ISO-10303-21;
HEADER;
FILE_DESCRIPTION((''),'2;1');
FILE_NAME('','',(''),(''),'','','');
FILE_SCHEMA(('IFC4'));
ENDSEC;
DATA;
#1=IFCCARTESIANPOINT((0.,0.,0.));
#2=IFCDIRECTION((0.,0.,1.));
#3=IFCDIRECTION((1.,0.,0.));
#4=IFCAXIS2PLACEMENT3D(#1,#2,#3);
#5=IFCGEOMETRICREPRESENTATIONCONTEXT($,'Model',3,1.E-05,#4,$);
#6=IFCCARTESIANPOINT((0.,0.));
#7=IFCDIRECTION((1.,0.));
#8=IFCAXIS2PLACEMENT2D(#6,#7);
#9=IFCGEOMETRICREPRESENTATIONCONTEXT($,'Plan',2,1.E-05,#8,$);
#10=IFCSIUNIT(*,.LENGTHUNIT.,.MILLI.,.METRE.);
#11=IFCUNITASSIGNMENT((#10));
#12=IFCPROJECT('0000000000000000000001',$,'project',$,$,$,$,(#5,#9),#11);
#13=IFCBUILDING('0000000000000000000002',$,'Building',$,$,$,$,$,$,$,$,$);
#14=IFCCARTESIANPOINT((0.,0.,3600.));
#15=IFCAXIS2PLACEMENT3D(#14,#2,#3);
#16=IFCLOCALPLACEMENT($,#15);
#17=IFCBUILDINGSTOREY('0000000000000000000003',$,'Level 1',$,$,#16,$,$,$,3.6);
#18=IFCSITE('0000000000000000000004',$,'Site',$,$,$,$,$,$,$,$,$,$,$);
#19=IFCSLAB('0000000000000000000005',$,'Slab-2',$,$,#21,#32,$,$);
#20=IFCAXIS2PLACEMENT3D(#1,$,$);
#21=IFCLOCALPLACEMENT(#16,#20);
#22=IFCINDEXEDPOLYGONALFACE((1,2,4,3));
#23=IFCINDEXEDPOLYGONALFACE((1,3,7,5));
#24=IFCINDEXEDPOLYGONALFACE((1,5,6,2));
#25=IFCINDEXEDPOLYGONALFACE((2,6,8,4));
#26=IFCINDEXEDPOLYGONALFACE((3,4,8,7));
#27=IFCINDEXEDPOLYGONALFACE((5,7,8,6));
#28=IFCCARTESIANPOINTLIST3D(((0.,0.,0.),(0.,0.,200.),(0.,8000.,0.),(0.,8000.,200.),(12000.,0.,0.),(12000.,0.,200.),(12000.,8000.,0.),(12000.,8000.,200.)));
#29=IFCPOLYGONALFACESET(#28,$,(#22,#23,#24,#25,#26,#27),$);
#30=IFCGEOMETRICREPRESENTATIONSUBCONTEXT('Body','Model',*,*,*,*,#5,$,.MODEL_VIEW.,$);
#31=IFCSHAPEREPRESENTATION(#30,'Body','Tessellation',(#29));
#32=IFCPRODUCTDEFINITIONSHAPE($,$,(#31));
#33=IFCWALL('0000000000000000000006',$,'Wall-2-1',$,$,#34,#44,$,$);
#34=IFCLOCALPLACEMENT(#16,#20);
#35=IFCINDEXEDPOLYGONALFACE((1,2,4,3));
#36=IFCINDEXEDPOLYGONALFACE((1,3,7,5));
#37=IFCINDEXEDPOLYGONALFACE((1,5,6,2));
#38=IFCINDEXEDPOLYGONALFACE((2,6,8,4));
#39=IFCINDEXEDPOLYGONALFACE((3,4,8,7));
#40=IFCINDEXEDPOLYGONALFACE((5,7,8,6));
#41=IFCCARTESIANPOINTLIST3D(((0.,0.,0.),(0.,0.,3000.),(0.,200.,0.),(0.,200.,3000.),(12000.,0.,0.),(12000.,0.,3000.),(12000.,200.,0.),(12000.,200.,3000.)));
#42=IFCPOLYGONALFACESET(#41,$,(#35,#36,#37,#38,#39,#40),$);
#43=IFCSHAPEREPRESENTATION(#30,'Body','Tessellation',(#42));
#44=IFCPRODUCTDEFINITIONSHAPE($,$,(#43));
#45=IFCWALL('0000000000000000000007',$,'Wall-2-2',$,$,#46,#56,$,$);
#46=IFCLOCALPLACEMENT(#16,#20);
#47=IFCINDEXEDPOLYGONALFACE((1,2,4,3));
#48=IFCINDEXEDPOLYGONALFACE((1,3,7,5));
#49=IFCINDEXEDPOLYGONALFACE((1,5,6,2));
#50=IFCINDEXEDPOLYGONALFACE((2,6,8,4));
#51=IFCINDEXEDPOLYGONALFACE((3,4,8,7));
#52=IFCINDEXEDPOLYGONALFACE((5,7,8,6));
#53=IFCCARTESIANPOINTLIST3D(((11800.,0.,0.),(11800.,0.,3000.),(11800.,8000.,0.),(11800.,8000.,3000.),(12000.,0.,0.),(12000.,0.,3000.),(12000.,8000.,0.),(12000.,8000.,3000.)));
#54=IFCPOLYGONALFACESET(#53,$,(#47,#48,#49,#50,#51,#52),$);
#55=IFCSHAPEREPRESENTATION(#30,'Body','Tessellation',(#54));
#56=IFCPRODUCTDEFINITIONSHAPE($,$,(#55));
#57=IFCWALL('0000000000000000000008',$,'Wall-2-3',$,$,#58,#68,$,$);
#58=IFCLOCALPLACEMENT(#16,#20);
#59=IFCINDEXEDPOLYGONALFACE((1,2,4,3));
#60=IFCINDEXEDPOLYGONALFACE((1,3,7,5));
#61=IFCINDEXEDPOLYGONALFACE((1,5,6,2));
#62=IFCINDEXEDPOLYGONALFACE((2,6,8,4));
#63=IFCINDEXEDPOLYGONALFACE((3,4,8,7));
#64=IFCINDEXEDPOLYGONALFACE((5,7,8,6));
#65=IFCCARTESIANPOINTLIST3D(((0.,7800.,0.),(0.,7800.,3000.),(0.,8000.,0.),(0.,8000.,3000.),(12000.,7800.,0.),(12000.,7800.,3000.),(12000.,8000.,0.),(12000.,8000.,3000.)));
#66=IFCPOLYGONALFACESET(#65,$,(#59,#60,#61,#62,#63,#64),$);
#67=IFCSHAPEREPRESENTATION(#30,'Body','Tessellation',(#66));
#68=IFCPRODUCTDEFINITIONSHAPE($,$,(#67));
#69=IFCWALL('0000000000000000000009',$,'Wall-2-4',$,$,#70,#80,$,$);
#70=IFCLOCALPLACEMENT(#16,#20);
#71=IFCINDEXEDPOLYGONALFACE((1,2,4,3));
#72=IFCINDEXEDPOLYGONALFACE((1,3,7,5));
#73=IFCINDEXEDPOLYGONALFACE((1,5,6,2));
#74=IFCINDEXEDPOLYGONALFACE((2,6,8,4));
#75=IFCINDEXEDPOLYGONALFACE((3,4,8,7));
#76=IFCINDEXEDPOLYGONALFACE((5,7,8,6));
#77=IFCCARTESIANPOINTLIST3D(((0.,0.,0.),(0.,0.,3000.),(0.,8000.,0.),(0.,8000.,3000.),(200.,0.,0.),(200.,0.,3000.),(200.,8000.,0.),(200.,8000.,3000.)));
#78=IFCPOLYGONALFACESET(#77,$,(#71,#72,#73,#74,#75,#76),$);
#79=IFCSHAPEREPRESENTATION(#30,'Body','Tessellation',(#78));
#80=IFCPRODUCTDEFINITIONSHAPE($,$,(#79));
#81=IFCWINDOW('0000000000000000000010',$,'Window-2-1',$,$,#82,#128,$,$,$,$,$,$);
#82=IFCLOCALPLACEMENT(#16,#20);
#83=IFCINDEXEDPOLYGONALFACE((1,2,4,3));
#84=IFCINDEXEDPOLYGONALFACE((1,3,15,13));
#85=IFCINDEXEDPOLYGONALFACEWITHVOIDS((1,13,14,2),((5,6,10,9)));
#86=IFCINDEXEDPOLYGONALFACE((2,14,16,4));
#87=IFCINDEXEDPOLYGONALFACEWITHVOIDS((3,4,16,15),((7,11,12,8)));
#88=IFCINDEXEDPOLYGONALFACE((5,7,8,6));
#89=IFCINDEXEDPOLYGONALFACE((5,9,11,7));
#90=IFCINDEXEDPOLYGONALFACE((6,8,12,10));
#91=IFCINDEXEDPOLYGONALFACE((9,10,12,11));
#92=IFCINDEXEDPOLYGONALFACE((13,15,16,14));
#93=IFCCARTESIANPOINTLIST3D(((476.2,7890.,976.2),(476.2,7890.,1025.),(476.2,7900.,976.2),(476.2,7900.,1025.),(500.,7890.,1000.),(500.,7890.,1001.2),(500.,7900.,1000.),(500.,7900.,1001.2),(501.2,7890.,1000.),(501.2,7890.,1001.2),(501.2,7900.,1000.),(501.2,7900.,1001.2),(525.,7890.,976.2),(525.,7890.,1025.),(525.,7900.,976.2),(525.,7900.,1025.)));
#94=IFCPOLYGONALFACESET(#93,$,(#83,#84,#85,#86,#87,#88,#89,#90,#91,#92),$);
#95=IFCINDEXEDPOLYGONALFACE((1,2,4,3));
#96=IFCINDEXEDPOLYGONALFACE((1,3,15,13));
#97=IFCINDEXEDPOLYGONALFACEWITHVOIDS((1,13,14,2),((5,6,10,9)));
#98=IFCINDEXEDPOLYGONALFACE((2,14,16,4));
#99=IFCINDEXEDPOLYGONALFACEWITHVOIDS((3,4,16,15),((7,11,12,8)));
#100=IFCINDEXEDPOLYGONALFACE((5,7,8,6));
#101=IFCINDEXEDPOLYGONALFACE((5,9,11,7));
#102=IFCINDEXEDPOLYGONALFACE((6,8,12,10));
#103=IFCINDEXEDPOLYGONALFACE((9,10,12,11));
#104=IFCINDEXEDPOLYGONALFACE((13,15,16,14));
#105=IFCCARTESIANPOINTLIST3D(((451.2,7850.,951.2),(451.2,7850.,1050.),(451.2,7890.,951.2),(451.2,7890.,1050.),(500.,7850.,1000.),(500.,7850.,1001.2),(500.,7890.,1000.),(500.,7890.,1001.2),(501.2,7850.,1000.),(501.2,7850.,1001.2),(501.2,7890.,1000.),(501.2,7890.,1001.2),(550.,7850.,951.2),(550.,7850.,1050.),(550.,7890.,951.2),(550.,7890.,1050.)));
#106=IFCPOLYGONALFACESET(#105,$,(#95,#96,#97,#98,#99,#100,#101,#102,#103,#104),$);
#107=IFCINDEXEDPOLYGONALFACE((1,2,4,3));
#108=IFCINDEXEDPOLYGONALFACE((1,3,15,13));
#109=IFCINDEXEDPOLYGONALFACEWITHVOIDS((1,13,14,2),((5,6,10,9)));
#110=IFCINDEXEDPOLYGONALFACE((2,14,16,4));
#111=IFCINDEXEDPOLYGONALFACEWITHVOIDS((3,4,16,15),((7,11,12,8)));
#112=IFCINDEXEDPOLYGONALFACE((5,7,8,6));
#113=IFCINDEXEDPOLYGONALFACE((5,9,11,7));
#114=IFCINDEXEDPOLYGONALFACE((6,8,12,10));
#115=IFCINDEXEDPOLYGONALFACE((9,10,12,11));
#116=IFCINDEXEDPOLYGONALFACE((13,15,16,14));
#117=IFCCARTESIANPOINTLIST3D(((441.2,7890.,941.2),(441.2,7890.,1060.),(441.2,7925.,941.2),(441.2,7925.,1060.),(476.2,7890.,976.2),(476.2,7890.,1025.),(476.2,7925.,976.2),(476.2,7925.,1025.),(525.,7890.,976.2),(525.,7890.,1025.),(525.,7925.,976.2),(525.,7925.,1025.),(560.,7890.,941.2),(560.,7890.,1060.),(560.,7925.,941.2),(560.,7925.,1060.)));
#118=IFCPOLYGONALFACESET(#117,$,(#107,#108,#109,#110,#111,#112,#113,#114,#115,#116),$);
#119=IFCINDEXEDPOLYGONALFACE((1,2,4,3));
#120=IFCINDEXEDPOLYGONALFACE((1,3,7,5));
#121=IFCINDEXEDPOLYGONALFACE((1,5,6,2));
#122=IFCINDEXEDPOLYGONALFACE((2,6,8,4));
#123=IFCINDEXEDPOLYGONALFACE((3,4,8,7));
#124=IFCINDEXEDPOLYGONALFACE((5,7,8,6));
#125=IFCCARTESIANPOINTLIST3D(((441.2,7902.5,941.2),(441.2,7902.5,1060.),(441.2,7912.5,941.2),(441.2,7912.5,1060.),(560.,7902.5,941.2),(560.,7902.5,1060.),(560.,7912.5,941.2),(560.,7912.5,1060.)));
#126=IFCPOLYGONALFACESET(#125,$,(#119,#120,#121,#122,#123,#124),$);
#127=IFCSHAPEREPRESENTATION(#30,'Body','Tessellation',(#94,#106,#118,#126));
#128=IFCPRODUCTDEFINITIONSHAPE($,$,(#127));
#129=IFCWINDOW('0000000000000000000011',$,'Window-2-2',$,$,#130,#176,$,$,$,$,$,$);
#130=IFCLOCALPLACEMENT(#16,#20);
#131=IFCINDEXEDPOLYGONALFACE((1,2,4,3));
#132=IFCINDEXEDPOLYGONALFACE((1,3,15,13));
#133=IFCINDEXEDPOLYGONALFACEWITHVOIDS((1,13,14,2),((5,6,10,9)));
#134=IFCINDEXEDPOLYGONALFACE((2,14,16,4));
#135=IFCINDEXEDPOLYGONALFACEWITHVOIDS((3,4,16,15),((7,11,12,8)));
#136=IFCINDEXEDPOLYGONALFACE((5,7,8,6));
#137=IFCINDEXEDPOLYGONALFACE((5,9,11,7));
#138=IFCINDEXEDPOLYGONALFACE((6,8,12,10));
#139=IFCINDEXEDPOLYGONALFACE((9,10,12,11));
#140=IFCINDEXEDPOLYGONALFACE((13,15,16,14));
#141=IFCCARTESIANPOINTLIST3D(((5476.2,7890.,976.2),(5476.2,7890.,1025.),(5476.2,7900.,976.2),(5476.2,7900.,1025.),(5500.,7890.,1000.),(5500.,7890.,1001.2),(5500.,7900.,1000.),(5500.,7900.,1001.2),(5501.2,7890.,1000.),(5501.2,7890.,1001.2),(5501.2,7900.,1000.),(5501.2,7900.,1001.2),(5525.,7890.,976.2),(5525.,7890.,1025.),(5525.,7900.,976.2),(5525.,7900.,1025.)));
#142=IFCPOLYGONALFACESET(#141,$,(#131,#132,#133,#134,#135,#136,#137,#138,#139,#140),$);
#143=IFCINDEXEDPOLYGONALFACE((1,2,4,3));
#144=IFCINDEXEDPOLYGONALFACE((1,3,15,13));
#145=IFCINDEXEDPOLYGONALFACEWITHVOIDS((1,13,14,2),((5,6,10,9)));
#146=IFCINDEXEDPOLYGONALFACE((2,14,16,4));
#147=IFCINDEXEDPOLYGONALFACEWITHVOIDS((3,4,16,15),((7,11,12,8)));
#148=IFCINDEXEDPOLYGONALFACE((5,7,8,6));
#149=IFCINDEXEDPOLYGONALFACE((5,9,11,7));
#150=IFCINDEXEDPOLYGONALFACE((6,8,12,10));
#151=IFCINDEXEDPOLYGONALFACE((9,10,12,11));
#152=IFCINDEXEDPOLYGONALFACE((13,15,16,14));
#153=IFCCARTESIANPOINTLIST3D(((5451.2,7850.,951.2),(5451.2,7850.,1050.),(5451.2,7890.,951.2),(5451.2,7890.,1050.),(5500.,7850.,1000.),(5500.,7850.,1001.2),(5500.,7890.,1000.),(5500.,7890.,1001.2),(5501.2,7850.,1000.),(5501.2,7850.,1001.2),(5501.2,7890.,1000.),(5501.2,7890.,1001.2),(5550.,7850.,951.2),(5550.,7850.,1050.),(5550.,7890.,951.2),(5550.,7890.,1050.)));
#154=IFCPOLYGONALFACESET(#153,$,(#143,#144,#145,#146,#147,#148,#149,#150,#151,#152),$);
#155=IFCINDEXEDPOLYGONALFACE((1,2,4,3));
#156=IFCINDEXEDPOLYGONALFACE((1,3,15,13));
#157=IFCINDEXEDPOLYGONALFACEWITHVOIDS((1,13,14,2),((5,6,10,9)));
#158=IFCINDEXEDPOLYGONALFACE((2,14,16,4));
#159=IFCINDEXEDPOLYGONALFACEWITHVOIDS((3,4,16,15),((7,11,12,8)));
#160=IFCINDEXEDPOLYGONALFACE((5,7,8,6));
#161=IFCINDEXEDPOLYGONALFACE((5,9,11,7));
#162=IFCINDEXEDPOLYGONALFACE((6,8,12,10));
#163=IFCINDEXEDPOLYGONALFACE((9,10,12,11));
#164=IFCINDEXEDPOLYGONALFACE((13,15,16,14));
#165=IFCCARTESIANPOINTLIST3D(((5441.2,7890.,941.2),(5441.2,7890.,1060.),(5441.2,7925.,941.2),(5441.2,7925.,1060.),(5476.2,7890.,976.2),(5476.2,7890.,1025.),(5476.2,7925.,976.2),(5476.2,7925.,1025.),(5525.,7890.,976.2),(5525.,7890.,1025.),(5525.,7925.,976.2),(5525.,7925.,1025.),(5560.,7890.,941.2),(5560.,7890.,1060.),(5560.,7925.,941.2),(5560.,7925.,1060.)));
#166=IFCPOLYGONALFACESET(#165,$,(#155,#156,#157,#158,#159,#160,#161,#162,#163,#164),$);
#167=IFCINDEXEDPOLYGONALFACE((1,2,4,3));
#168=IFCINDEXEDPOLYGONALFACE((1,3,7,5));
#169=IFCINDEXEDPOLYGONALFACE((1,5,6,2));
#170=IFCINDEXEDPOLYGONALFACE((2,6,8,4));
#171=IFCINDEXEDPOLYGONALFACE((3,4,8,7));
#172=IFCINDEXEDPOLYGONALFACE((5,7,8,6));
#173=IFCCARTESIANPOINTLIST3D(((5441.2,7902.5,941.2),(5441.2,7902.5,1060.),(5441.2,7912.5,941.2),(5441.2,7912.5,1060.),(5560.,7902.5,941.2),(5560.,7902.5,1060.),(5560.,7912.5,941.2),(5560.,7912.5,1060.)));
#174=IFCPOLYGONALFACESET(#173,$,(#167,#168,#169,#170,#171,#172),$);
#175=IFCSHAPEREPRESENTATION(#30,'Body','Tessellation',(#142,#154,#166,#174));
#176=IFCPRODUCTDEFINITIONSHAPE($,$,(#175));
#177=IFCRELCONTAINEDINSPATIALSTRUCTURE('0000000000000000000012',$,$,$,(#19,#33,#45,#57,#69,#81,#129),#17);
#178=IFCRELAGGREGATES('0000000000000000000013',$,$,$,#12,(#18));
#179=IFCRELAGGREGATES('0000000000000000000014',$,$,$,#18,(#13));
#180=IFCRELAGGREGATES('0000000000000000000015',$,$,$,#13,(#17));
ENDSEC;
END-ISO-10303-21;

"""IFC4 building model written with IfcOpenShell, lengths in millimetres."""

from ifc_helpers import new_model, si_unit, frame, origin_with_axes, origin_2d_with_axis, place, context, subcontext, project, spatial, line, indexed_curve, outline, extrude, element, save


model = new_model("IFC4")

# Units and contexts
model_context = context("Model", 3, precision=1e-05, world=origin_with_axes())
plan_context = context("Plan", 2, precision=1e-05, world=origin_2d_with_axis())
body_context = subcontext(model_context, "Body", "Model", "MODEL_VIEW")
ifc_project = project(units=[si_unit("LENGTHUNIT", "METRE", prefix="MILLI")], contexts=[model_context, plan_context])

# Site, building, storey
site = spatial("IfcSite", under=ifc_project, Name="Site")
building = spatial("IfcBuilding", under=site, Name="Building")
storey_placement = place(None, frame((0.0, 0.0, 3600.0), z_axis=(0.0, 0.0, 1.0), x_axis=(1.0, 0.0, 0.0)))
storey = spatial("IfcBuildingStorey", under=building, at=storey_placement, Name="Level 1", Elevation=3.6)

# Slab
slab_placement = place(storey_placement, origin_with_axes())
element("IfcSlab", 1, at=slab_placement, inside=storey, Name="Slab-2", context=body_context, shape_type="SweptSolid", body=[
    extrude(outline(indexed_curve([(0.0, 0.0), (12000.0, 0.0), (12000.0, 8000.0), (0.0, 8000.0), (0.0, 0.0)])), None, (0.0, 0.0, 1.0), 200.0),
])

# Walls
wall_1_placement = place(storey_placement, origin_with_axes())
element("IfcWall", 2, at=wall_1_placement, inside=storey, Name="Wall-2-1", context=body_context, shape_type="SweptSolid", body=[
    extrude(outline(indexed_curve([(0.0, 0.0), (0.0, 200.0), (12000.0, 200.0), (12000.0, 0.0), (0.0, 0.0)], self_intersect=False)), origin_with_axes(), (0.0, 0.0, 1.0), 3000.0),
])
wall_2_placement = place(storey_placement, frame((12000.0, 0.0, 0.0), z_axis=(0.0, 0.0, 1.0), x_axis=(0.0, 1.0, 0.0)))
element("IfcWall", 3, at=wall_2_placement, inside=storey, Name="Wall-2-2", context=body_context, shape_type="SweptSolid", body=[
    extrude(outline(indexed_curve([(0.0, 0.0), (0.0, 200.0), (8000.0, 200.0), (8000.0, 0.0), (0.0, 0.0)], self_intersect=False)), origin_with_axes(), (0.0, 0.0, 1.0), 3000.0),
])
wall_3_placement = place(storey_placement, frame((12000.0, 8000.0, 0.0), z_axis=(0.0, 0.0, 1.0), x_axis=(-1.0, 0.0, 0.0)))
element("IfcWall", 4, at=wall_3_placement, inside=storey, Name="Wall-2-3", context=body_context, shape_type="SweptSolid", body=[
    extrude(outline(indexed_curve([(0.0, 0.0), (0.0, 200.0), (12000.0, 200.0), (12000.0, 0.0), (0.0, 0.0)], self_intersect=False)), origin_with_axes(), (0.0, 0.0, 1.0), 3000.0),
])
wall_4_placement = place(storey_placement, frame((0.0, 8000.0, 0.0), z_axis=(0.0, 0.0, 1.0), x_axis=(0.0, -1.0, 0.0)))
element("IfcWall", 5, at=wall_4_placement, inside=storey, Name="Wall-2-4", context=body_context, shape_type="SweptSolid", body=[
    extrude(outline(indexed_curve([(0.0, 0.0), (0.0, 200.0), (8000.0, 200.0), (8000.0, 0.0), (0.0, 0.0)], self_intersect=False)), origin_with_axes(), (0.0, 0.0, 1.0), 3000.0),
])

# Windows
for number, where, z_axis, x_axis, name in (
    (6, (500.0, 7800.0, 1000.0), (0.0, 0.0, 1.0), (1.0, 0.0, 0.0), "Window-2-1"),
    (7, (5500.0, 7800.0, 1000.0), (0.0, 0.0, 1.0), (1.0, 0.0, 0.0), "Window-2-2"),
):
    element("IfcWindow", number, at=place(storey_placement, frame(where, z_axis=z_axis, x_axis=x_axis)), inside=storey, Name=name, context=body_context, shape_type="SweptSolid", body=[
        extrude(outline(indexed_curve([(0.0, 0.0), (1.2, 0.0), (1.2, 1.2), (0.0, 1.2)], segments=[line(1, 2, 3, 4, 1)]), holes=[indexed_curve([(25.0, 25.0), (-23.8, 25.0), (-23.8, -23.8), (25.0, -23.8)], segments=[line(1, 2, 3, 4, 1)])]), frame((0.0, 90.0, 0.0), z_axis=(0.0, -1.0, 0.0), x_axis=(1.0, 0.0, 0.0)), (0.0, 0.0, -1.0), 10.0),
        extrude(outline(indexed_curve([(0.0, 0.0), (1.2, 0.0), (1.2, 1.2), (0.0, 1.2)], segments=[line(1, 2, 3, 4, 1)]), holes=[indexed_curve([(50.0, 50.0), (-48.8, 50.0), (-48.8, -48.8), (50.0, -48.8)], segments=[line(1, 2, 3, 4, 1)])]), frame((0.0, 50.0, 0.0), z_axis=(0.0, -1.0, 0.0), x_axis=(1.0, 0.0, 0.0)), (0.0, 0.0, -1.0), 40.0),
        extrude(outline(indexed_curve([(0.0, 0.0), (-48.8, 0.0), (-48.8, -48.8), (0.0, -48.8)], segments=[line(1, 2, 3, 4, 1)]), holes=[indexed_curve([(35.0, 35.0), (-83.8, 35.0), (-83.8, -83.8), (35.0, -83.8)], segments=[line(1, 2, 3, 4, 1)])]), frame((25.0, 90.0, 25.0), z_axis=(0.0, -1.0, 0.0), x_axis=(1.0, 0.0, 0.0)), (0.0, 0.0, -1.0), 35.0),
        extrude(outline(indexed_curve([(35.0, 35.0), (-83.8, 35.0), (-83.8, -83.8), (35.0, -83.8)], segments=[line(1, 2, 3, 4, 1)])), frame((25.0, 102.5, 25.0), z_axis=(0.0, -1.0, 0.0), x_axis=(1.0, 0.0, 0.0)), (0.0, 0.0, -1.0), 10.0),
    ])

save(model, "model.ifc")
